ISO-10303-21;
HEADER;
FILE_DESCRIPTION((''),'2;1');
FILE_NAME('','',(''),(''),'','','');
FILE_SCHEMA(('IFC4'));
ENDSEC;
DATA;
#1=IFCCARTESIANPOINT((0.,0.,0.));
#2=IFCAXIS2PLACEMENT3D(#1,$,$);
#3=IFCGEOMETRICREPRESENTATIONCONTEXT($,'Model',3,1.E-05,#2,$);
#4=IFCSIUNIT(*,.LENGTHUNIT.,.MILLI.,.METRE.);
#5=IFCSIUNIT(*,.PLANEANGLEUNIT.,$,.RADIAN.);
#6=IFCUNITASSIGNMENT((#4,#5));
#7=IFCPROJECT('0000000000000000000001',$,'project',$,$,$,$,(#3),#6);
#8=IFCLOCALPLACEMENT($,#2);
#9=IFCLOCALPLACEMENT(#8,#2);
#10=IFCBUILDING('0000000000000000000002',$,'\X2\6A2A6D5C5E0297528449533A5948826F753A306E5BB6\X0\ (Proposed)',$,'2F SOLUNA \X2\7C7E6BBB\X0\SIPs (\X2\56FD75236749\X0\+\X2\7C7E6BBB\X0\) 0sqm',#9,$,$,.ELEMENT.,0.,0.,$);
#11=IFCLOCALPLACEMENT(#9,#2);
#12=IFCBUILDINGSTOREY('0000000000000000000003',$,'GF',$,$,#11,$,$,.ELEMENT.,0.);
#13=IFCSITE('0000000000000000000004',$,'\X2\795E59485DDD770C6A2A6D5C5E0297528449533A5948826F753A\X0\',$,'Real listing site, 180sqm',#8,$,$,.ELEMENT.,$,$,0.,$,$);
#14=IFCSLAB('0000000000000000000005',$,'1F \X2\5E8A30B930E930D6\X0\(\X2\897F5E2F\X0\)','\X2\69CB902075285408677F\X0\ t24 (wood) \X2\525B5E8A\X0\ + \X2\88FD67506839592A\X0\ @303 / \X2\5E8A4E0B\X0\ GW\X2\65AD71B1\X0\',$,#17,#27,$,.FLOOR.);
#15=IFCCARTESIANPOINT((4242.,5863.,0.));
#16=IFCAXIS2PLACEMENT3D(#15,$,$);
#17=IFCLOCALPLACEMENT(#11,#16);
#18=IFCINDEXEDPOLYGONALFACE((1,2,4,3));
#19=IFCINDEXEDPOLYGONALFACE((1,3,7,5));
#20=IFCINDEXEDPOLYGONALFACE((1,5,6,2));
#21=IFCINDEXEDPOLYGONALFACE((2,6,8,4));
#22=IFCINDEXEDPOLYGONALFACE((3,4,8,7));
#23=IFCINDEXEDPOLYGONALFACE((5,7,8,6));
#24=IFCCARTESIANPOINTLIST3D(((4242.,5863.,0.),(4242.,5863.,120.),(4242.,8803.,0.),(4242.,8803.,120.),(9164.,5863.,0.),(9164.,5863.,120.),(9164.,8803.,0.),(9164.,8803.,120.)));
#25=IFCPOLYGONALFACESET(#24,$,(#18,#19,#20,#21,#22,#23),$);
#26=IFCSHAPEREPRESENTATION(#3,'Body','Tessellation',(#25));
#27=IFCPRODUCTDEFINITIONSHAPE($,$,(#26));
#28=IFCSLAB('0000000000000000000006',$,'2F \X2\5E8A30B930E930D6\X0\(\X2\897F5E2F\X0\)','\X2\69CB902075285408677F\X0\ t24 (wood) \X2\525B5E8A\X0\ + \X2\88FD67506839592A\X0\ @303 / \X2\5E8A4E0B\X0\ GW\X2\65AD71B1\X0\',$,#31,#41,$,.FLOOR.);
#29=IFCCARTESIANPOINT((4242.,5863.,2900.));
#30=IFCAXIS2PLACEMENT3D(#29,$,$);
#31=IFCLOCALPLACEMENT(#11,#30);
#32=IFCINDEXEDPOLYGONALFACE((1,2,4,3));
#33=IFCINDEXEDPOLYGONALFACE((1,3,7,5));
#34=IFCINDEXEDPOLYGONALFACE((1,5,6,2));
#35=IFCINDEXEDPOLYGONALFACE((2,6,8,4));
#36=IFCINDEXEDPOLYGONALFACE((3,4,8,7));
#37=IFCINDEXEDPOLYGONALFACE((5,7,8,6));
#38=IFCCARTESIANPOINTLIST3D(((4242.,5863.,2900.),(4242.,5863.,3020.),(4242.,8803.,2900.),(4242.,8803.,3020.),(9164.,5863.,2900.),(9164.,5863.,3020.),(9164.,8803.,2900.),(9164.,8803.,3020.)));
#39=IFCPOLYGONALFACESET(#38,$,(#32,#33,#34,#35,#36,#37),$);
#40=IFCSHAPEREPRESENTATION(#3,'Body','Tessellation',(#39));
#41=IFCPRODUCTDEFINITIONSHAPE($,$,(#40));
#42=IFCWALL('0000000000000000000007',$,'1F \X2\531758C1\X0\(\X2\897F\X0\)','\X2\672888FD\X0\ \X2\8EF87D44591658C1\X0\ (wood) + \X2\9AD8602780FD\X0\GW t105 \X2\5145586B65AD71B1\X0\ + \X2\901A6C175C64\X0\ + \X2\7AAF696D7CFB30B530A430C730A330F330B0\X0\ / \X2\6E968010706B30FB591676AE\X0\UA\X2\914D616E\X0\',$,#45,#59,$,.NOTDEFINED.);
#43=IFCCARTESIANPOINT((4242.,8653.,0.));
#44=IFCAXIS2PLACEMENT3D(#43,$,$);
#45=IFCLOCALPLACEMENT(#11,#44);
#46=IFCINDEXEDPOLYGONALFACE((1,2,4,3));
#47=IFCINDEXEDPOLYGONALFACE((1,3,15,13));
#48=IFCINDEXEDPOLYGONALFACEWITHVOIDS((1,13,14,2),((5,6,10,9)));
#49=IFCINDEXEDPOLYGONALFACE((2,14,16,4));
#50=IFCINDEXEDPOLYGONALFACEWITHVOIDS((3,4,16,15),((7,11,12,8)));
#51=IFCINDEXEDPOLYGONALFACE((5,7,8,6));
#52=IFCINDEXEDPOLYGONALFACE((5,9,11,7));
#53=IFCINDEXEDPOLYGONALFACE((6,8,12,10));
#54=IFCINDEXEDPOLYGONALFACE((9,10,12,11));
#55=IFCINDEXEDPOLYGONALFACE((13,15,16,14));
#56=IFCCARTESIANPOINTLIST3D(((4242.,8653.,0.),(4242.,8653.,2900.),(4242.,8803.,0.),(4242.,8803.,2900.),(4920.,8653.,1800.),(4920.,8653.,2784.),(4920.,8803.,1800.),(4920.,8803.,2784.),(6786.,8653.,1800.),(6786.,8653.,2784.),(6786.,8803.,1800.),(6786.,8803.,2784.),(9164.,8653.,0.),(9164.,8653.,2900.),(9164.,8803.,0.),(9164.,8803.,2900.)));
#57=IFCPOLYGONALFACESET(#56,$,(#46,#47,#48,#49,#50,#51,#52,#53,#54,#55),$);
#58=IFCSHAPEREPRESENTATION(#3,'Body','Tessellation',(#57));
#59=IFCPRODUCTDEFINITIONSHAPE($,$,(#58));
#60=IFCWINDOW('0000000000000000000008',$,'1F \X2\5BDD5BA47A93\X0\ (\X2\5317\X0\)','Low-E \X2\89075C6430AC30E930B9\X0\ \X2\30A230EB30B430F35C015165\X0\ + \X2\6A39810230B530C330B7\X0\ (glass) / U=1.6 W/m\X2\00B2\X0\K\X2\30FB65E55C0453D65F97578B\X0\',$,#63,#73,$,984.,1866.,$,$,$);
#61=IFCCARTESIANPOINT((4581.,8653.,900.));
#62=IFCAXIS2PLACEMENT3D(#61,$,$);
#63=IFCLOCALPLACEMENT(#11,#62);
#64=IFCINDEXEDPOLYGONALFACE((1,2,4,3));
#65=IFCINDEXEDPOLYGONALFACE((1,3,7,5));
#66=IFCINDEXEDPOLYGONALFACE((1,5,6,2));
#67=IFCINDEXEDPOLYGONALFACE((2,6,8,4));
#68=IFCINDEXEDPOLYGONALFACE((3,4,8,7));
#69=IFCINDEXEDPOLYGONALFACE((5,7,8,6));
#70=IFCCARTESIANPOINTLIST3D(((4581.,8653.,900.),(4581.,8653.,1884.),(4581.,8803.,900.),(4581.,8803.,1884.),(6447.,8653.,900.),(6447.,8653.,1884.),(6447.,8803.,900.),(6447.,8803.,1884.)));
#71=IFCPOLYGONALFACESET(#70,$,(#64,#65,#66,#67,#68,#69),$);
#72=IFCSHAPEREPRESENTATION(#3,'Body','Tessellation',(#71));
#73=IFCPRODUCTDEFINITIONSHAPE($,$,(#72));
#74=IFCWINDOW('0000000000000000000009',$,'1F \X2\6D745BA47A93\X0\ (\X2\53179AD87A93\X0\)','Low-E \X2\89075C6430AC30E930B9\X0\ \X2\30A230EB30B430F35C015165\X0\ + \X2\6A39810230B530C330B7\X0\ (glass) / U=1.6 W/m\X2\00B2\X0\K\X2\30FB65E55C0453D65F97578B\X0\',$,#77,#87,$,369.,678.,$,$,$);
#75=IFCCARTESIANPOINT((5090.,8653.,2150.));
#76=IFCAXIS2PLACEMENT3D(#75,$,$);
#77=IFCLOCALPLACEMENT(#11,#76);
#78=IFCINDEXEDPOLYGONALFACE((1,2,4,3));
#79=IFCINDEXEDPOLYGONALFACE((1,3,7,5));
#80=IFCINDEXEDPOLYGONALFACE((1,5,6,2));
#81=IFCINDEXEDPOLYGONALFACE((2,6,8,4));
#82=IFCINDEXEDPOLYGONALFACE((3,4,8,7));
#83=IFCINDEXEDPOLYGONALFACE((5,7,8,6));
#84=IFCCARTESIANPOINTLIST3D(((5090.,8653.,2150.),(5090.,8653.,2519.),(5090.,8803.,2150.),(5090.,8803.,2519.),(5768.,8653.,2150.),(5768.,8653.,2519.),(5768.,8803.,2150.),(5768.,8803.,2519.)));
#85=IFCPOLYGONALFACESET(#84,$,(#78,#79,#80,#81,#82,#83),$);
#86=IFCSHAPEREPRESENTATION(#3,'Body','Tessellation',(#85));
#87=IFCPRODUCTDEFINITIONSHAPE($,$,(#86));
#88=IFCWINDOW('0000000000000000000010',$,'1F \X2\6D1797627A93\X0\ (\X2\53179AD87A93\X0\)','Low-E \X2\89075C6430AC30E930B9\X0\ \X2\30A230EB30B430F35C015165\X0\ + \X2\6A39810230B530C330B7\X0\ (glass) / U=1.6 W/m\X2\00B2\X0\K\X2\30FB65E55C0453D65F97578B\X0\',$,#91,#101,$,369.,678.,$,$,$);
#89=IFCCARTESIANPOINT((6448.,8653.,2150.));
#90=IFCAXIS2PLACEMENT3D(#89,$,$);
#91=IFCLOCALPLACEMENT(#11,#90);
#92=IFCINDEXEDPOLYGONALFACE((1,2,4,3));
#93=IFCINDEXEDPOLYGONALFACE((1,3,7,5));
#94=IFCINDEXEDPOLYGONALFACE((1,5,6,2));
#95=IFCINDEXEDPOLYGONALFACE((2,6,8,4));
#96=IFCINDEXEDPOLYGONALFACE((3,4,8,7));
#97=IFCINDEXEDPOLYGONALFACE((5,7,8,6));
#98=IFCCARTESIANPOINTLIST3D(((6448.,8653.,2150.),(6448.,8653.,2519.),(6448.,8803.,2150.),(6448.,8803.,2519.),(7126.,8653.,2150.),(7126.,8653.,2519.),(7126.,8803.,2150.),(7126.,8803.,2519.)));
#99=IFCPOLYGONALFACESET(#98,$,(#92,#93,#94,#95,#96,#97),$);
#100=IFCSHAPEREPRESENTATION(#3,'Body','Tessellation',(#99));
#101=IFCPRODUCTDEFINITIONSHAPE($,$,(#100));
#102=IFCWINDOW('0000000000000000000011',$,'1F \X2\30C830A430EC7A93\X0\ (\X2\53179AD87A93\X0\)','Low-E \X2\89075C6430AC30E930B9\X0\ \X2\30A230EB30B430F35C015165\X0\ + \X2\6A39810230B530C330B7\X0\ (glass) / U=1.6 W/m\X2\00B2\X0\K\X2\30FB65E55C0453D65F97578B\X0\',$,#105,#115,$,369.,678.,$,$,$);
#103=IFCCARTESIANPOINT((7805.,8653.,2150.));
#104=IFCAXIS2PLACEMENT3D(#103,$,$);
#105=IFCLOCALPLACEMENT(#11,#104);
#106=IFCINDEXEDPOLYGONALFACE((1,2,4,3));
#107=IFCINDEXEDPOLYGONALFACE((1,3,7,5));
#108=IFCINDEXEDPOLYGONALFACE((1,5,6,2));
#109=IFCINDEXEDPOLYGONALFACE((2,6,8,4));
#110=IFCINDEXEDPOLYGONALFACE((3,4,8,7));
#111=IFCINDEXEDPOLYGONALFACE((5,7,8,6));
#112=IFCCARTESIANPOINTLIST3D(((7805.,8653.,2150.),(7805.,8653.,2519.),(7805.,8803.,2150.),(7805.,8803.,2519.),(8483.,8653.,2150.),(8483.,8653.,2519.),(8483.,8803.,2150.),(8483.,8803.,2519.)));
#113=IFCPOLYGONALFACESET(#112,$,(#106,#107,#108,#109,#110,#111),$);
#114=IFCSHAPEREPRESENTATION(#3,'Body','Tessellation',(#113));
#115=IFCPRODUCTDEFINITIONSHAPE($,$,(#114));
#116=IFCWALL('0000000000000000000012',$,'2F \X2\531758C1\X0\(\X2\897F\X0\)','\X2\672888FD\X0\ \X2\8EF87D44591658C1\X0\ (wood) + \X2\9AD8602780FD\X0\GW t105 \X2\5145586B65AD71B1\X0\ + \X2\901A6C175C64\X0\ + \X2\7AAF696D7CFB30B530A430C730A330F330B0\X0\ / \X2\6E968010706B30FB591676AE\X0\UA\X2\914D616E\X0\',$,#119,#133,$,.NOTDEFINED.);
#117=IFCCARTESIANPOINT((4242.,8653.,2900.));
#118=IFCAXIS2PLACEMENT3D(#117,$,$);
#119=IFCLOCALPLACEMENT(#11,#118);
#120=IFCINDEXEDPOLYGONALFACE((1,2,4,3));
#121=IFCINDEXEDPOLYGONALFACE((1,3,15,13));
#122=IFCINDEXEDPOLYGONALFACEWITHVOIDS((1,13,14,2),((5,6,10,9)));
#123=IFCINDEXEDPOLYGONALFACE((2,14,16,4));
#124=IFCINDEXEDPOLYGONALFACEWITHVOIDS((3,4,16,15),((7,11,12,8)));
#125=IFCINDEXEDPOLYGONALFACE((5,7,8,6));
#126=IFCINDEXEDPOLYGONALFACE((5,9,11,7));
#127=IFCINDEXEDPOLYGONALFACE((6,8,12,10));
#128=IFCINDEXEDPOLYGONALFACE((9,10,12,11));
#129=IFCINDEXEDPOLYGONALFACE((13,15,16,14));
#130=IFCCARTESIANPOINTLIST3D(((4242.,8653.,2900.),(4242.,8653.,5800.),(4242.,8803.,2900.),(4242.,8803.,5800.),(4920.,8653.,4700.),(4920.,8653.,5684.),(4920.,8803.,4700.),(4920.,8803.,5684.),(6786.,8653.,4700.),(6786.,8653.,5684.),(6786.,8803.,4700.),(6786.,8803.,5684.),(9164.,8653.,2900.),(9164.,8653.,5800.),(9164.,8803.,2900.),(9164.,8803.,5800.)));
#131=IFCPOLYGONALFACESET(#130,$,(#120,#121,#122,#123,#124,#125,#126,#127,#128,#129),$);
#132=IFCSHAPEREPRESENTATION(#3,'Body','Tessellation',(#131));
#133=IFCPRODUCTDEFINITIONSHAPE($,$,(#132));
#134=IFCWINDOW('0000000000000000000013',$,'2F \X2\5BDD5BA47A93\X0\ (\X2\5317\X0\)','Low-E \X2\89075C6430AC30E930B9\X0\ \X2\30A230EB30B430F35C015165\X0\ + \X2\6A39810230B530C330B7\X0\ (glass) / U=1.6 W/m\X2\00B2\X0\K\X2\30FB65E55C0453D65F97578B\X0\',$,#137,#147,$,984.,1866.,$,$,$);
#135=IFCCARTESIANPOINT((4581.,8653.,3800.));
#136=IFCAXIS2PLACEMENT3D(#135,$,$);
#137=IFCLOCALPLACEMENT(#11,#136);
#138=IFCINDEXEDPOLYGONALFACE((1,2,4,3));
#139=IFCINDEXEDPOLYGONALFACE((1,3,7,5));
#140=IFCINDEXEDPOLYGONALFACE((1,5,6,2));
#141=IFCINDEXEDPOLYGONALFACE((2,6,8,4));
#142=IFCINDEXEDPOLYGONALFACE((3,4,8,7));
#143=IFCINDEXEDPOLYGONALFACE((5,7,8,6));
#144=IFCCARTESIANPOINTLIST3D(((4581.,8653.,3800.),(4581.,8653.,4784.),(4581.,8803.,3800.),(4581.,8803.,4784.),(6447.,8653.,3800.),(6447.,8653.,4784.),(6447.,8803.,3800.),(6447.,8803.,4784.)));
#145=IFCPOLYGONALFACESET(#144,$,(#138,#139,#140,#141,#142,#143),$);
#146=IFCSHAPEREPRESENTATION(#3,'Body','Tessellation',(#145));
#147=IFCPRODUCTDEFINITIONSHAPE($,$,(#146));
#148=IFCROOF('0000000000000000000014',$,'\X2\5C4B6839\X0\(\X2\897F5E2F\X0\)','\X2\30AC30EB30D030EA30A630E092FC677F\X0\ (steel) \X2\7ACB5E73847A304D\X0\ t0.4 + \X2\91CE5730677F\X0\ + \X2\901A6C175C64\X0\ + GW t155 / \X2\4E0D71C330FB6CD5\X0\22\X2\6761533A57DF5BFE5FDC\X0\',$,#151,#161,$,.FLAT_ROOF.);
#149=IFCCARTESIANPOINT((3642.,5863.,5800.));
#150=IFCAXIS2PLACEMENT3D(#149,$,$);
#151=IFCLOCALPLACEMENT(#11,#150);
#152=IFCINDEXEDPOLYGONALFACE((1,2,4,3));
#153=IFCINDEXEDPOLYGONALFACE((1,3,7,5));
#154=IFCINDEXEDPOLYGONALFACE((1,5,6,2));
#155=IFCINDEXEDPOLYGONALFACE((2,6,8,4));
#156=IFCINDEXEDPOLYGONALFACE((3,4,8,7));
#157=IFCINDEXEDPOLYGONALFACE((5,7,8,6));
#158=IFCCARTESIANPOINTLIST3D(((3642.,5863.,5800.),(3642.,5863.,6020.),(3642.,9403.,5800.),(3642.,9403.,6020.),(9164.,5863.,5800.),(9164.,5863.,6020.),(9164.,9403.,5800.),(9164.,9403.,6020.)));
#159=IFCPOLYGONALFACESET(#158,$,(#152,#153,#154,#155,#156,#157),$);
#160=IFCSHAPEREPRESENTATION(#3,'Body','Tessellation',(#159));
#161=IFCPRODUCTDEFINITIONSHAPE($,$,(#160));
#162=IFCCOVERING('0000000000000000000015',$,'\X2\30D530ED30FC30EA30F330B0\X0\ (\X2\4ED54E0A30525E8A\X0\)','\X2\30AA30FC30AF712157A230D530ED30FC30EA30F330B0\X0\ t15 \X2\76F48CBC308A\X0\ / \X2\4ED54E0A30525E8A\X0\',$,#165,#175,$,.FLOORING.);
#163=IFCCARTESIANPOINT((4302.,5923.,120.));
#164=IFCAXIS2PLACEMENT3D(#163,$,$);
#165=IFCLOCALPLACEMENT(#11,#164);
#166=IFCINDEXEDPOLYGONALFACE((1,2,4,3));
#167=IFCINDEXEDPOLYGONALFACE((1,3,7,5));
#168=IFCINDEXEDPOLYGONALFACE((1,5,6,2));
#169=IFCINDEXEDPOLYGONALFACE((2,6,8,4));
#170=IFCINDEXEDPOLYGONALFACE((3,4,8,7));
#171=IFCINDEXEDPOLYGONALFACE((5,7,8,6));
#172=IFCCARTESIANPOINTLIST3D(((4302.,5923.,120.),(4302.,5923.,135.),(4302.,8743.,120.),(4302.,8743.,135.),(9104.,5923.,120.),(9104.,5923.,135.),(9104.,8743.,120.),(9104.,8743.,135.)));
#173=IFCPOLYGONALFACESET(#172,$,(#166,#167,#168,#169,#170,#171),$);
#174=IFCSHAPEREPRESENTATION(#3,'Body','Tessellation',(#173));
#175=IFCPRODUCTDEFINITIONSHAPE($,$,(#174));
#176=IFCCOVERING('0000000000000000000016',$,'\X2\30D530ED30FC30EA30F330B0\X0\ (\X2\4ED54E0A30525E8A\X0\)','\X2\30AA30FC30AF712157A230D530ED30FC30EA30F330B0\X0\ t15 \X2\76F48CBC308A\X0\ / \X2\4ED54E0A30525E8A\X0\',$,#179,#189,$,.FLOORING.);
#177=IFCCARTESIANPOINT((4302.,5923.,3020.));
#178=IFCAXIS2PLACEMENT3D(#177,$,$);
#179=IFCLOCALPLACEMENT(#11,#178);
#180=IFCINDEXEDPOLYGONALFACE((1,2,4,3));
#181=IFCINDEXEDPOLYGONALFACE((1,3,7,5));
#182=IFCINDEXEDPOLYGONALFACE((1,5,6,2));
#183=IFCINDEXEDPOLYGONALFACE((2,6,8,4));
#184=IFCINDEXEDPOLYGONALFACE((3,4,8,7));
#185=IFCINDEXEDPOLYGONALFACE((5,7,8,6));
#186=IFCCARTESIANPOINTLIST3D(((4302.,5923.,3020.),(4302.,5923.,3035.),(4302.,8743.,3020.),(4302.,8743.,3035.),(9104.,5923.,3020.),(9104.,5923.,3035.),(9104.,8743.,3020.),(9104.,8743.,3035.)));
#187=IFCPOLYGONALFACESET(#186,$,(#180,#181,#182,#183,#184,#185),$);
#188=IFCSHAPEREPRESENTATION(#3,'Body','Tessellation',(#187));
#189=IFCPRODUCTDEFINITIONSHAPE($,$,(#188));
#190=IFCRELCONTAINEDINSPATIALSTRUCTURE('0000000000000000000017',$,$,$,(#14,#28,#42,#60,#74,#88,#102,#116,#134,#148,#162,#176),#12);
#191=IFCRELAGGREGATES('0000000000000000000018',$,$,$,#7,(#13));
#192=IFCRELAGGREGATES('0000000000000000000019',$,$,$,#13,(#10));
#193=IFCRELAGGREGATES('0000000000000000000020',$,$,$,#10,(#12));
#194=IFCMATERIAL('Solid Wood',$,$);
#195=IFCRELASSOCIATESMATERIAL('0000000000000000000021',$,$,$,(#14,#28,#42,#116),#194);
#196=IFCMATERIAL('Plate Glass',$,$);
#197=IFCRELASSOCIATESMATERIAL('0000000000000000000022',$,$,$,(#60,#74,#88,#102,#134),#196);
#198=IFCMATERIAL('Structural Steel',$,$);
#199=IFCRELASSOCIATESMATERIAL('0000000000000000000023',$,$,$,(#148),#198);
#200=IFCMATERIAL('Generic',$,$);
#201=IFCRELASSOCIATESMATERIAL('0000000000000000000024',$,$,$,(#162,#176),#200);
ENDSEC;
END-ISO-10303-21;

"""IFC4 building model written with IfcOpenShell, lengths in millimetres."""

from ifc_helpers import new_model, si_unit, frame, frame_2d, origin, place, context, project, spatial, rectangle, extrude, material, element, fill, save


model = new_model("IFC4")

# Units and contexts
model_context = context("Model", 3, precision=1e-05, world=origin())
ifc_project = project(units=[si_unit("LENGTHUNIT", "METRE", prefix="MILLI"), si_unit("PLANEANGLEUNIT", "RADIAN")], contexts=[model_context])

# Site, building, storey
site_placement = place(None, origin())
site = spatial("IfcSite", under=ifc_project, at=site_placement, Name="神奈川県横浜市青葉区奈良町", ObjectType="Real listing site, 180sqm", CompositionType="ELEMENT", RefElevation=0.0)
building_placement = place(site_placement, origin())
building = spatial("IfcBuilding", under=site, at=building_placement, Name="横浜市青葉区奈良町の家 (Proposed)", ObjectType="2F SOLUNA 籾殻SIPs (国産杉+籾殻) 0sqm", CompositionType="ELEMENT", ElevationOfRefHeight=0.0, ElevationOfTerrain=0.0)
storey_placement = place(building_placement, origin())
storey = spatial("IfcBuildingStorey", under=building, at=storey_placement, Name="GF", CompositionType="ELEMENT", Elevation=0.0)

# Slabs
ifc_material_1 = material(Name="Solid Wood")
slab_1_placement = place(storey_placement, frame((4242.0, 5863.0, 0.0)))
element("IfcSlab", 1, at=slab_1_placement, inside=storey, material=ifc_material_1, Name="1F 床スラブ(西帯)", Description="構造用合板 t24 (wood) 剛床 + 製材根太 @303 / 床下 GW断熱", PredefinedType="FLOOR", context=model_context, shape_type="SweptSolid", body=[
    extrude(rectangle(XDim=4922.0, YDim=2940.0, at=frame_2d((2461.0, 1470.0))), frame((4242.0, 5863.0, 0.0)), (0.0, 0.0, 1.0), 120.0),
])
slab_2_placement = place(storey_placement, frame((4242.0, 5863.0, 2900.0)))
element("IfcSlab", 2, at=slab_2_placement, inside=storey, material=ifc_material_1, Name="2F 床スラブ(西帯)", Description="構造用合板 t24 (wood) 剛床 + 製材根太 @303 / 床下 GW断熱", PredefinedType="FLOOR", context=model_context, shape_type="SweptSolid", body=[
    extrude(rectangle(XDim=4922.0, YDim=2940.0, at=frame_2d((2461.0, 1470.0))), frame((4242.0, 5863.0, 2900.0)), (0.0, 0.0, 1.0), 120.0),
])

# Wall, openings, windows
wall_1_placement = place(storey_placement, frame((4242.0, 8653.0, 0.0)))
wall_1 = element("IfcWall", 3, at=wall_1_placement, inside=storey, material=ifc_material_1, Name="1F 北壁(西)", Description="木製 軸組外壁 (wood) + 高性能GW t105 充填断熱 + 通気層 + 窯業系サイディング / 準耐火・外皮UA配慮", PredefinedType="NOTDEFINED", context=model_context, shape_type="SweptSolid", body=[
    extrude(rectangle(XDim=4922.0, YDim=150.0, at=frame_2d((2461.0, 75.0))), frame((4242.0, 8653.0, 0.0)), (0.0, 0.0, 1.0), 2900.0),
])
opening_1_placement = place(storey_placement, frame((4581.0, 8653.0, 900.0)))
opening_1 = element("IfcOpeningElement", 4, at=opening_1_placement, cuts=wall_1, PredefinedType="NOTDEFINED", context=model_context, shape_type="SweptSolid", body=[
    extrude(rectangle(XDim=1866.0, YDim=150.0, at=frame_2d((933.0, 75.0))), frame((4581.0, 8653.0, 900.0)), (0.0, 0.0, 1.0), 984.0),
])
opening_2_placement = place(storey_placement, frame((5090.0, 8653.0, 2150.0)))
opening_2 = element("IfcOpeningElement", 5, at=opening_2_placement, cuts=wall_1, PredefinedType="NOTDEFINED", context=model_context, shape_type="SweptSolid", body=[
    extrude(rectangle(XDim=678.0, YDim=150.0, at=frame_2d((339.0, 75.0))), frame((5090.0, 8653.0, 2150.0)), (0.0, 0.0, 1.0), 369.0),
])
opening_3_placement = place(storey_placement, frame((6448.0, 8653.0, 2150.0)))
opening_3 = element("IfcOpeningElement", 6, at=opening_3_placement, cuts=wall_1, PredefinedType="NOTDEFINED", context=model_context, shape_type="SweptSolid", body=[
    extrude(rectangle(XDim=678.0, YDim=150.0, at=frame_2d((339.0, 75.0))), frame((6448.0, 8653.0, 2150.0)), (0.0, 0.0, 1.0), 369.0),
])
opening_4_placement = place(storey_placement, frame((7805.0, 8653.0, 2150.0)))
opening_4 = element("IfcOpeningElement", 7, at=opening_4_placement, cuts=wall_1, PredefinedType="NOTDEFINED", context=model_context, shape_type="SweptSolid", body=[
    extrude(rectangle(XDim=678.0, YDim=150.0, at=frame_2d((339.0, 75.0))), frame((7805.0, 8653.0, 2150.0)), (0.0, 0.0, 1.0), 369.0),
])
ifc_material_2 = material(Name="Plate Glass")
window_1_placement = place(storey_placement, frame((4581.0, 8653.0, 900.0)))
window_1 = element("IfcWindow", 8, at=window_1_placement, inside=storey, material=ifc_material_2, Name="1F 寝室窓 (北)", Description="Low-E 複層ガラス アルゴン封入 + 樹脂サッシ (glass) / U=1.6 W/m²K・日射取得型", OverallHeight=984.0, OverallWidth=1866.0, context=model_context, shape_type="SweptSolid", body=[
    extrude(rectangle(XDim=1866.0, YDim=150.0, at=frame_2d((933.0, 75.0))), frame((4581.0, 8653.0, 900.0)), (0.0, 0.0, 1.0), 984.0),
])
fill(opening_1, window_1)
window_2_placement = place(storey_placement, frame((5090.0, 8653.0, 2150.0)))
window_2 = element("IfcWindow", 9, at=window_2_placement, inside=storey, material=ifc_material_2, Name="1F 浴室窓 (北高窓)", Description="Low-E 複層ガラス アルゴン封入 + 樹脂サッシ (glass) / U=1.6 W/m²K・日射取得型", OverallHeight=369.0, OverallWidth=678.0, context=model_context, shape_type="SweptSolid", body=[
    extrude(rectangle(XDim=678.0, YDim=150.0, at=frame_2d((339.0, 75.0))), frame((5090.0, 8653.0, 2150.0)), (0.0, 0.0, 1.0), 369.0),
])
fill(opening_2, window_2)
window_3_placement = place(storey_placement, frame((6448.0, 8653.0, 2150.0)))
window_3 = element("IfcWindow", 10, at=window_3_placement, inside=storey, material=ifc_material_2, Name="1F 洗面窓 (北高窓)", Description="Low-E 複層ガラス アルゴン封入 + 樹脂サッシ (glass) / U=1.6 W/m²K・日射取得型", OverallHeight=369.0, OverallWidth=678.0, context=model_context, shape_type="SweptSolid", body=[
    extrude(rectangle(XDim=678.0, YDim=150.0, at=frame_2d((339.0, 75.0))), frame((6448.0, 8653.0, 2150.0)), (0.0, 0.0, 1.0), 369.0),
])
fill(opening_3, window_3)
window_4_placement = place(storey_placement, frame((7805.0, 8653.0, 2150.0)))
window_4 = element("IfcWindow", 11, at=window_4_placement, inside=storey, material=ifc_material_2, Name="1F トイレ窓 (北高窓)", Description="Low-E 複層ガラス アルゴン封入 + 樹脂サッシ (glass) / U=1.6 W/m²K・日射取得型", OverallHeight=369.0, OverallWidth=678.0, context=model_context, shape_type="SweptSolid", body=[
    extrude(rectangle(XDim=678.0, YDim=150.0, at=frame_2d((339.0, 75.0))), frame((7805.0, 8653.0, 2150.0)), (0.0, 0.0, 1.0), 369.0),
])
fill(opening_4, window_4)

# Wall, opening, window
wall_2_placement = place(storey_placement, frame((4242.0, 8653.0, 2900.0)))
wall_2 = element("IfcWall", 12, at=wall_2_placement, inside=storey, material=ifc_material_1, Name="2F 北壁(西)", Description="木製 軸組外壁 (wood) + 高性能GW t105 充填断熱 + 通気層 + 窯業系サイディング / 準耐火・外皮UA配慮", PredefinedType="NOTDEFINED", context=model_context, shape_type="SweptSolid", body=[
    extrude(rectangle(XDim=4922.0, YDim=150.0, at=frame_2d((2461.0, 75.0))), frame((4242.0, 8653.0, 2900.0)), (0.0, 0.0, 1.0), 2900.0),
])
opening_5_placement = place(storey_placement, frame((4581.0, 8653.0, 3800.0)))
opening_5 = element("IfcOpeningElement", 13, at=opening_5_placement, cuts=wall_2, PredefinedType="NOTDEFINED", context=model_context, shape_type="SweptSolid", body=[
    extrude(rectangle(XDim=1866.0, YDim=150.0, at=frame_2d((933.0, 75.0))), frame((4581.0, 8653.0, 3800.0)), (0.0, 0.0, 1.0), 984.0),
])
window_5_placement = place(storey_placement, frame((4581.0, 8653.0, 3800.0)))
window_5 = element("IfcWindow", 14, at=window_5_placement, inside=storey, material=ifc_material_2, Name="2F 寝室窓 (北)", Description="Low-E 複層ガラス アルゴン封入 + 樹脂サッシ (glass) / U=1.6 W/m²K・日射取得型", OverallHeight=984.0, OverallWidth=1866.0, context=model_context, shape_type="SweptSolid", body=[
    extrude(rectangle(XDim=1866.0, YDim=150.0, at=frame_2d((933.0, 75.0))), frame((4581.0, 8653.0, 3800.0)), (0.0, 0.0, 1.0), 984.0),
])
fill(opening_5, window_5)

# Roof
ifc_material_3 = material(Name="Structural Steel")
for number, where, name in (
    (15, (3642.0, 5863.0, 5800.0), "屋根(西帯)"),
):
    element("IfcRoof", number, at=place(storey_placement, frame(where)), inside=storey, material=ifc_material_3, Name=name, Description="ガルバリウム鋼板 (steel) 立平葺き t0.4 + 野地板 + 通気層 + GW t155 / 不燃・法22条区域対応", PredefinedType="FLAT_ROOF", context=model_context, shape_type="SweptSolid", body=[
        extrude(rectangle(XDim=5522.0, YDim=3540.0, at=frame_2d((2761.0, 1770.0))), frame((3642.0, 5863.0, 5800.0)), (0.0, 0.0, 1.0), 220.0),
    ])

# Coverings
ifc_material_4 = material(Name="Generic")
covering_1_placement = place(storey_placement, frame((4302.0, 5923.0, 120.0)))
element("IfcCovering", 16, at=covering_1_placement, inside=storey, material=ifc_material_4, Name="フローリング (仕上げ床)", Description="オーク無垢フローリング t15 直貼り / 仕上げ床", PredefinedType="FLOORING", context=model_context, shape_type="SweptSolid", body=[
    extrude(rectangle(XDim=4802.0, YDim=2820.0, at=frame_2d((2401.0, 1410.0))), frame((4302.0, 5923.0, 120.0)), (0.0, 0.0, 1.0), 15.0),
])
covering_2_placement = place(storey_placement, frame((4302.0, 5923.0, 3020.0)))
element("IfcCovering", 17, at=covering_2_placement, inside=storey, material=ifc_material_4, Name="フローリング (仕上げ床)", Description="オーク無垢フローリング t15 直貼り / 仕上げ床", PredefinedType="FLOORING", context=model_context, shape_type="SweptSolid", body=[
    extrude(rectangle(XDim=4802.0, YDim=2820.0, at=frame_2d((2401.0, 1410.0))), frame((4302.0, 5923.0, 3020.0)), (0.0, 0.0, 1.0), 15.0),
])

save(model, "model.ifc")
